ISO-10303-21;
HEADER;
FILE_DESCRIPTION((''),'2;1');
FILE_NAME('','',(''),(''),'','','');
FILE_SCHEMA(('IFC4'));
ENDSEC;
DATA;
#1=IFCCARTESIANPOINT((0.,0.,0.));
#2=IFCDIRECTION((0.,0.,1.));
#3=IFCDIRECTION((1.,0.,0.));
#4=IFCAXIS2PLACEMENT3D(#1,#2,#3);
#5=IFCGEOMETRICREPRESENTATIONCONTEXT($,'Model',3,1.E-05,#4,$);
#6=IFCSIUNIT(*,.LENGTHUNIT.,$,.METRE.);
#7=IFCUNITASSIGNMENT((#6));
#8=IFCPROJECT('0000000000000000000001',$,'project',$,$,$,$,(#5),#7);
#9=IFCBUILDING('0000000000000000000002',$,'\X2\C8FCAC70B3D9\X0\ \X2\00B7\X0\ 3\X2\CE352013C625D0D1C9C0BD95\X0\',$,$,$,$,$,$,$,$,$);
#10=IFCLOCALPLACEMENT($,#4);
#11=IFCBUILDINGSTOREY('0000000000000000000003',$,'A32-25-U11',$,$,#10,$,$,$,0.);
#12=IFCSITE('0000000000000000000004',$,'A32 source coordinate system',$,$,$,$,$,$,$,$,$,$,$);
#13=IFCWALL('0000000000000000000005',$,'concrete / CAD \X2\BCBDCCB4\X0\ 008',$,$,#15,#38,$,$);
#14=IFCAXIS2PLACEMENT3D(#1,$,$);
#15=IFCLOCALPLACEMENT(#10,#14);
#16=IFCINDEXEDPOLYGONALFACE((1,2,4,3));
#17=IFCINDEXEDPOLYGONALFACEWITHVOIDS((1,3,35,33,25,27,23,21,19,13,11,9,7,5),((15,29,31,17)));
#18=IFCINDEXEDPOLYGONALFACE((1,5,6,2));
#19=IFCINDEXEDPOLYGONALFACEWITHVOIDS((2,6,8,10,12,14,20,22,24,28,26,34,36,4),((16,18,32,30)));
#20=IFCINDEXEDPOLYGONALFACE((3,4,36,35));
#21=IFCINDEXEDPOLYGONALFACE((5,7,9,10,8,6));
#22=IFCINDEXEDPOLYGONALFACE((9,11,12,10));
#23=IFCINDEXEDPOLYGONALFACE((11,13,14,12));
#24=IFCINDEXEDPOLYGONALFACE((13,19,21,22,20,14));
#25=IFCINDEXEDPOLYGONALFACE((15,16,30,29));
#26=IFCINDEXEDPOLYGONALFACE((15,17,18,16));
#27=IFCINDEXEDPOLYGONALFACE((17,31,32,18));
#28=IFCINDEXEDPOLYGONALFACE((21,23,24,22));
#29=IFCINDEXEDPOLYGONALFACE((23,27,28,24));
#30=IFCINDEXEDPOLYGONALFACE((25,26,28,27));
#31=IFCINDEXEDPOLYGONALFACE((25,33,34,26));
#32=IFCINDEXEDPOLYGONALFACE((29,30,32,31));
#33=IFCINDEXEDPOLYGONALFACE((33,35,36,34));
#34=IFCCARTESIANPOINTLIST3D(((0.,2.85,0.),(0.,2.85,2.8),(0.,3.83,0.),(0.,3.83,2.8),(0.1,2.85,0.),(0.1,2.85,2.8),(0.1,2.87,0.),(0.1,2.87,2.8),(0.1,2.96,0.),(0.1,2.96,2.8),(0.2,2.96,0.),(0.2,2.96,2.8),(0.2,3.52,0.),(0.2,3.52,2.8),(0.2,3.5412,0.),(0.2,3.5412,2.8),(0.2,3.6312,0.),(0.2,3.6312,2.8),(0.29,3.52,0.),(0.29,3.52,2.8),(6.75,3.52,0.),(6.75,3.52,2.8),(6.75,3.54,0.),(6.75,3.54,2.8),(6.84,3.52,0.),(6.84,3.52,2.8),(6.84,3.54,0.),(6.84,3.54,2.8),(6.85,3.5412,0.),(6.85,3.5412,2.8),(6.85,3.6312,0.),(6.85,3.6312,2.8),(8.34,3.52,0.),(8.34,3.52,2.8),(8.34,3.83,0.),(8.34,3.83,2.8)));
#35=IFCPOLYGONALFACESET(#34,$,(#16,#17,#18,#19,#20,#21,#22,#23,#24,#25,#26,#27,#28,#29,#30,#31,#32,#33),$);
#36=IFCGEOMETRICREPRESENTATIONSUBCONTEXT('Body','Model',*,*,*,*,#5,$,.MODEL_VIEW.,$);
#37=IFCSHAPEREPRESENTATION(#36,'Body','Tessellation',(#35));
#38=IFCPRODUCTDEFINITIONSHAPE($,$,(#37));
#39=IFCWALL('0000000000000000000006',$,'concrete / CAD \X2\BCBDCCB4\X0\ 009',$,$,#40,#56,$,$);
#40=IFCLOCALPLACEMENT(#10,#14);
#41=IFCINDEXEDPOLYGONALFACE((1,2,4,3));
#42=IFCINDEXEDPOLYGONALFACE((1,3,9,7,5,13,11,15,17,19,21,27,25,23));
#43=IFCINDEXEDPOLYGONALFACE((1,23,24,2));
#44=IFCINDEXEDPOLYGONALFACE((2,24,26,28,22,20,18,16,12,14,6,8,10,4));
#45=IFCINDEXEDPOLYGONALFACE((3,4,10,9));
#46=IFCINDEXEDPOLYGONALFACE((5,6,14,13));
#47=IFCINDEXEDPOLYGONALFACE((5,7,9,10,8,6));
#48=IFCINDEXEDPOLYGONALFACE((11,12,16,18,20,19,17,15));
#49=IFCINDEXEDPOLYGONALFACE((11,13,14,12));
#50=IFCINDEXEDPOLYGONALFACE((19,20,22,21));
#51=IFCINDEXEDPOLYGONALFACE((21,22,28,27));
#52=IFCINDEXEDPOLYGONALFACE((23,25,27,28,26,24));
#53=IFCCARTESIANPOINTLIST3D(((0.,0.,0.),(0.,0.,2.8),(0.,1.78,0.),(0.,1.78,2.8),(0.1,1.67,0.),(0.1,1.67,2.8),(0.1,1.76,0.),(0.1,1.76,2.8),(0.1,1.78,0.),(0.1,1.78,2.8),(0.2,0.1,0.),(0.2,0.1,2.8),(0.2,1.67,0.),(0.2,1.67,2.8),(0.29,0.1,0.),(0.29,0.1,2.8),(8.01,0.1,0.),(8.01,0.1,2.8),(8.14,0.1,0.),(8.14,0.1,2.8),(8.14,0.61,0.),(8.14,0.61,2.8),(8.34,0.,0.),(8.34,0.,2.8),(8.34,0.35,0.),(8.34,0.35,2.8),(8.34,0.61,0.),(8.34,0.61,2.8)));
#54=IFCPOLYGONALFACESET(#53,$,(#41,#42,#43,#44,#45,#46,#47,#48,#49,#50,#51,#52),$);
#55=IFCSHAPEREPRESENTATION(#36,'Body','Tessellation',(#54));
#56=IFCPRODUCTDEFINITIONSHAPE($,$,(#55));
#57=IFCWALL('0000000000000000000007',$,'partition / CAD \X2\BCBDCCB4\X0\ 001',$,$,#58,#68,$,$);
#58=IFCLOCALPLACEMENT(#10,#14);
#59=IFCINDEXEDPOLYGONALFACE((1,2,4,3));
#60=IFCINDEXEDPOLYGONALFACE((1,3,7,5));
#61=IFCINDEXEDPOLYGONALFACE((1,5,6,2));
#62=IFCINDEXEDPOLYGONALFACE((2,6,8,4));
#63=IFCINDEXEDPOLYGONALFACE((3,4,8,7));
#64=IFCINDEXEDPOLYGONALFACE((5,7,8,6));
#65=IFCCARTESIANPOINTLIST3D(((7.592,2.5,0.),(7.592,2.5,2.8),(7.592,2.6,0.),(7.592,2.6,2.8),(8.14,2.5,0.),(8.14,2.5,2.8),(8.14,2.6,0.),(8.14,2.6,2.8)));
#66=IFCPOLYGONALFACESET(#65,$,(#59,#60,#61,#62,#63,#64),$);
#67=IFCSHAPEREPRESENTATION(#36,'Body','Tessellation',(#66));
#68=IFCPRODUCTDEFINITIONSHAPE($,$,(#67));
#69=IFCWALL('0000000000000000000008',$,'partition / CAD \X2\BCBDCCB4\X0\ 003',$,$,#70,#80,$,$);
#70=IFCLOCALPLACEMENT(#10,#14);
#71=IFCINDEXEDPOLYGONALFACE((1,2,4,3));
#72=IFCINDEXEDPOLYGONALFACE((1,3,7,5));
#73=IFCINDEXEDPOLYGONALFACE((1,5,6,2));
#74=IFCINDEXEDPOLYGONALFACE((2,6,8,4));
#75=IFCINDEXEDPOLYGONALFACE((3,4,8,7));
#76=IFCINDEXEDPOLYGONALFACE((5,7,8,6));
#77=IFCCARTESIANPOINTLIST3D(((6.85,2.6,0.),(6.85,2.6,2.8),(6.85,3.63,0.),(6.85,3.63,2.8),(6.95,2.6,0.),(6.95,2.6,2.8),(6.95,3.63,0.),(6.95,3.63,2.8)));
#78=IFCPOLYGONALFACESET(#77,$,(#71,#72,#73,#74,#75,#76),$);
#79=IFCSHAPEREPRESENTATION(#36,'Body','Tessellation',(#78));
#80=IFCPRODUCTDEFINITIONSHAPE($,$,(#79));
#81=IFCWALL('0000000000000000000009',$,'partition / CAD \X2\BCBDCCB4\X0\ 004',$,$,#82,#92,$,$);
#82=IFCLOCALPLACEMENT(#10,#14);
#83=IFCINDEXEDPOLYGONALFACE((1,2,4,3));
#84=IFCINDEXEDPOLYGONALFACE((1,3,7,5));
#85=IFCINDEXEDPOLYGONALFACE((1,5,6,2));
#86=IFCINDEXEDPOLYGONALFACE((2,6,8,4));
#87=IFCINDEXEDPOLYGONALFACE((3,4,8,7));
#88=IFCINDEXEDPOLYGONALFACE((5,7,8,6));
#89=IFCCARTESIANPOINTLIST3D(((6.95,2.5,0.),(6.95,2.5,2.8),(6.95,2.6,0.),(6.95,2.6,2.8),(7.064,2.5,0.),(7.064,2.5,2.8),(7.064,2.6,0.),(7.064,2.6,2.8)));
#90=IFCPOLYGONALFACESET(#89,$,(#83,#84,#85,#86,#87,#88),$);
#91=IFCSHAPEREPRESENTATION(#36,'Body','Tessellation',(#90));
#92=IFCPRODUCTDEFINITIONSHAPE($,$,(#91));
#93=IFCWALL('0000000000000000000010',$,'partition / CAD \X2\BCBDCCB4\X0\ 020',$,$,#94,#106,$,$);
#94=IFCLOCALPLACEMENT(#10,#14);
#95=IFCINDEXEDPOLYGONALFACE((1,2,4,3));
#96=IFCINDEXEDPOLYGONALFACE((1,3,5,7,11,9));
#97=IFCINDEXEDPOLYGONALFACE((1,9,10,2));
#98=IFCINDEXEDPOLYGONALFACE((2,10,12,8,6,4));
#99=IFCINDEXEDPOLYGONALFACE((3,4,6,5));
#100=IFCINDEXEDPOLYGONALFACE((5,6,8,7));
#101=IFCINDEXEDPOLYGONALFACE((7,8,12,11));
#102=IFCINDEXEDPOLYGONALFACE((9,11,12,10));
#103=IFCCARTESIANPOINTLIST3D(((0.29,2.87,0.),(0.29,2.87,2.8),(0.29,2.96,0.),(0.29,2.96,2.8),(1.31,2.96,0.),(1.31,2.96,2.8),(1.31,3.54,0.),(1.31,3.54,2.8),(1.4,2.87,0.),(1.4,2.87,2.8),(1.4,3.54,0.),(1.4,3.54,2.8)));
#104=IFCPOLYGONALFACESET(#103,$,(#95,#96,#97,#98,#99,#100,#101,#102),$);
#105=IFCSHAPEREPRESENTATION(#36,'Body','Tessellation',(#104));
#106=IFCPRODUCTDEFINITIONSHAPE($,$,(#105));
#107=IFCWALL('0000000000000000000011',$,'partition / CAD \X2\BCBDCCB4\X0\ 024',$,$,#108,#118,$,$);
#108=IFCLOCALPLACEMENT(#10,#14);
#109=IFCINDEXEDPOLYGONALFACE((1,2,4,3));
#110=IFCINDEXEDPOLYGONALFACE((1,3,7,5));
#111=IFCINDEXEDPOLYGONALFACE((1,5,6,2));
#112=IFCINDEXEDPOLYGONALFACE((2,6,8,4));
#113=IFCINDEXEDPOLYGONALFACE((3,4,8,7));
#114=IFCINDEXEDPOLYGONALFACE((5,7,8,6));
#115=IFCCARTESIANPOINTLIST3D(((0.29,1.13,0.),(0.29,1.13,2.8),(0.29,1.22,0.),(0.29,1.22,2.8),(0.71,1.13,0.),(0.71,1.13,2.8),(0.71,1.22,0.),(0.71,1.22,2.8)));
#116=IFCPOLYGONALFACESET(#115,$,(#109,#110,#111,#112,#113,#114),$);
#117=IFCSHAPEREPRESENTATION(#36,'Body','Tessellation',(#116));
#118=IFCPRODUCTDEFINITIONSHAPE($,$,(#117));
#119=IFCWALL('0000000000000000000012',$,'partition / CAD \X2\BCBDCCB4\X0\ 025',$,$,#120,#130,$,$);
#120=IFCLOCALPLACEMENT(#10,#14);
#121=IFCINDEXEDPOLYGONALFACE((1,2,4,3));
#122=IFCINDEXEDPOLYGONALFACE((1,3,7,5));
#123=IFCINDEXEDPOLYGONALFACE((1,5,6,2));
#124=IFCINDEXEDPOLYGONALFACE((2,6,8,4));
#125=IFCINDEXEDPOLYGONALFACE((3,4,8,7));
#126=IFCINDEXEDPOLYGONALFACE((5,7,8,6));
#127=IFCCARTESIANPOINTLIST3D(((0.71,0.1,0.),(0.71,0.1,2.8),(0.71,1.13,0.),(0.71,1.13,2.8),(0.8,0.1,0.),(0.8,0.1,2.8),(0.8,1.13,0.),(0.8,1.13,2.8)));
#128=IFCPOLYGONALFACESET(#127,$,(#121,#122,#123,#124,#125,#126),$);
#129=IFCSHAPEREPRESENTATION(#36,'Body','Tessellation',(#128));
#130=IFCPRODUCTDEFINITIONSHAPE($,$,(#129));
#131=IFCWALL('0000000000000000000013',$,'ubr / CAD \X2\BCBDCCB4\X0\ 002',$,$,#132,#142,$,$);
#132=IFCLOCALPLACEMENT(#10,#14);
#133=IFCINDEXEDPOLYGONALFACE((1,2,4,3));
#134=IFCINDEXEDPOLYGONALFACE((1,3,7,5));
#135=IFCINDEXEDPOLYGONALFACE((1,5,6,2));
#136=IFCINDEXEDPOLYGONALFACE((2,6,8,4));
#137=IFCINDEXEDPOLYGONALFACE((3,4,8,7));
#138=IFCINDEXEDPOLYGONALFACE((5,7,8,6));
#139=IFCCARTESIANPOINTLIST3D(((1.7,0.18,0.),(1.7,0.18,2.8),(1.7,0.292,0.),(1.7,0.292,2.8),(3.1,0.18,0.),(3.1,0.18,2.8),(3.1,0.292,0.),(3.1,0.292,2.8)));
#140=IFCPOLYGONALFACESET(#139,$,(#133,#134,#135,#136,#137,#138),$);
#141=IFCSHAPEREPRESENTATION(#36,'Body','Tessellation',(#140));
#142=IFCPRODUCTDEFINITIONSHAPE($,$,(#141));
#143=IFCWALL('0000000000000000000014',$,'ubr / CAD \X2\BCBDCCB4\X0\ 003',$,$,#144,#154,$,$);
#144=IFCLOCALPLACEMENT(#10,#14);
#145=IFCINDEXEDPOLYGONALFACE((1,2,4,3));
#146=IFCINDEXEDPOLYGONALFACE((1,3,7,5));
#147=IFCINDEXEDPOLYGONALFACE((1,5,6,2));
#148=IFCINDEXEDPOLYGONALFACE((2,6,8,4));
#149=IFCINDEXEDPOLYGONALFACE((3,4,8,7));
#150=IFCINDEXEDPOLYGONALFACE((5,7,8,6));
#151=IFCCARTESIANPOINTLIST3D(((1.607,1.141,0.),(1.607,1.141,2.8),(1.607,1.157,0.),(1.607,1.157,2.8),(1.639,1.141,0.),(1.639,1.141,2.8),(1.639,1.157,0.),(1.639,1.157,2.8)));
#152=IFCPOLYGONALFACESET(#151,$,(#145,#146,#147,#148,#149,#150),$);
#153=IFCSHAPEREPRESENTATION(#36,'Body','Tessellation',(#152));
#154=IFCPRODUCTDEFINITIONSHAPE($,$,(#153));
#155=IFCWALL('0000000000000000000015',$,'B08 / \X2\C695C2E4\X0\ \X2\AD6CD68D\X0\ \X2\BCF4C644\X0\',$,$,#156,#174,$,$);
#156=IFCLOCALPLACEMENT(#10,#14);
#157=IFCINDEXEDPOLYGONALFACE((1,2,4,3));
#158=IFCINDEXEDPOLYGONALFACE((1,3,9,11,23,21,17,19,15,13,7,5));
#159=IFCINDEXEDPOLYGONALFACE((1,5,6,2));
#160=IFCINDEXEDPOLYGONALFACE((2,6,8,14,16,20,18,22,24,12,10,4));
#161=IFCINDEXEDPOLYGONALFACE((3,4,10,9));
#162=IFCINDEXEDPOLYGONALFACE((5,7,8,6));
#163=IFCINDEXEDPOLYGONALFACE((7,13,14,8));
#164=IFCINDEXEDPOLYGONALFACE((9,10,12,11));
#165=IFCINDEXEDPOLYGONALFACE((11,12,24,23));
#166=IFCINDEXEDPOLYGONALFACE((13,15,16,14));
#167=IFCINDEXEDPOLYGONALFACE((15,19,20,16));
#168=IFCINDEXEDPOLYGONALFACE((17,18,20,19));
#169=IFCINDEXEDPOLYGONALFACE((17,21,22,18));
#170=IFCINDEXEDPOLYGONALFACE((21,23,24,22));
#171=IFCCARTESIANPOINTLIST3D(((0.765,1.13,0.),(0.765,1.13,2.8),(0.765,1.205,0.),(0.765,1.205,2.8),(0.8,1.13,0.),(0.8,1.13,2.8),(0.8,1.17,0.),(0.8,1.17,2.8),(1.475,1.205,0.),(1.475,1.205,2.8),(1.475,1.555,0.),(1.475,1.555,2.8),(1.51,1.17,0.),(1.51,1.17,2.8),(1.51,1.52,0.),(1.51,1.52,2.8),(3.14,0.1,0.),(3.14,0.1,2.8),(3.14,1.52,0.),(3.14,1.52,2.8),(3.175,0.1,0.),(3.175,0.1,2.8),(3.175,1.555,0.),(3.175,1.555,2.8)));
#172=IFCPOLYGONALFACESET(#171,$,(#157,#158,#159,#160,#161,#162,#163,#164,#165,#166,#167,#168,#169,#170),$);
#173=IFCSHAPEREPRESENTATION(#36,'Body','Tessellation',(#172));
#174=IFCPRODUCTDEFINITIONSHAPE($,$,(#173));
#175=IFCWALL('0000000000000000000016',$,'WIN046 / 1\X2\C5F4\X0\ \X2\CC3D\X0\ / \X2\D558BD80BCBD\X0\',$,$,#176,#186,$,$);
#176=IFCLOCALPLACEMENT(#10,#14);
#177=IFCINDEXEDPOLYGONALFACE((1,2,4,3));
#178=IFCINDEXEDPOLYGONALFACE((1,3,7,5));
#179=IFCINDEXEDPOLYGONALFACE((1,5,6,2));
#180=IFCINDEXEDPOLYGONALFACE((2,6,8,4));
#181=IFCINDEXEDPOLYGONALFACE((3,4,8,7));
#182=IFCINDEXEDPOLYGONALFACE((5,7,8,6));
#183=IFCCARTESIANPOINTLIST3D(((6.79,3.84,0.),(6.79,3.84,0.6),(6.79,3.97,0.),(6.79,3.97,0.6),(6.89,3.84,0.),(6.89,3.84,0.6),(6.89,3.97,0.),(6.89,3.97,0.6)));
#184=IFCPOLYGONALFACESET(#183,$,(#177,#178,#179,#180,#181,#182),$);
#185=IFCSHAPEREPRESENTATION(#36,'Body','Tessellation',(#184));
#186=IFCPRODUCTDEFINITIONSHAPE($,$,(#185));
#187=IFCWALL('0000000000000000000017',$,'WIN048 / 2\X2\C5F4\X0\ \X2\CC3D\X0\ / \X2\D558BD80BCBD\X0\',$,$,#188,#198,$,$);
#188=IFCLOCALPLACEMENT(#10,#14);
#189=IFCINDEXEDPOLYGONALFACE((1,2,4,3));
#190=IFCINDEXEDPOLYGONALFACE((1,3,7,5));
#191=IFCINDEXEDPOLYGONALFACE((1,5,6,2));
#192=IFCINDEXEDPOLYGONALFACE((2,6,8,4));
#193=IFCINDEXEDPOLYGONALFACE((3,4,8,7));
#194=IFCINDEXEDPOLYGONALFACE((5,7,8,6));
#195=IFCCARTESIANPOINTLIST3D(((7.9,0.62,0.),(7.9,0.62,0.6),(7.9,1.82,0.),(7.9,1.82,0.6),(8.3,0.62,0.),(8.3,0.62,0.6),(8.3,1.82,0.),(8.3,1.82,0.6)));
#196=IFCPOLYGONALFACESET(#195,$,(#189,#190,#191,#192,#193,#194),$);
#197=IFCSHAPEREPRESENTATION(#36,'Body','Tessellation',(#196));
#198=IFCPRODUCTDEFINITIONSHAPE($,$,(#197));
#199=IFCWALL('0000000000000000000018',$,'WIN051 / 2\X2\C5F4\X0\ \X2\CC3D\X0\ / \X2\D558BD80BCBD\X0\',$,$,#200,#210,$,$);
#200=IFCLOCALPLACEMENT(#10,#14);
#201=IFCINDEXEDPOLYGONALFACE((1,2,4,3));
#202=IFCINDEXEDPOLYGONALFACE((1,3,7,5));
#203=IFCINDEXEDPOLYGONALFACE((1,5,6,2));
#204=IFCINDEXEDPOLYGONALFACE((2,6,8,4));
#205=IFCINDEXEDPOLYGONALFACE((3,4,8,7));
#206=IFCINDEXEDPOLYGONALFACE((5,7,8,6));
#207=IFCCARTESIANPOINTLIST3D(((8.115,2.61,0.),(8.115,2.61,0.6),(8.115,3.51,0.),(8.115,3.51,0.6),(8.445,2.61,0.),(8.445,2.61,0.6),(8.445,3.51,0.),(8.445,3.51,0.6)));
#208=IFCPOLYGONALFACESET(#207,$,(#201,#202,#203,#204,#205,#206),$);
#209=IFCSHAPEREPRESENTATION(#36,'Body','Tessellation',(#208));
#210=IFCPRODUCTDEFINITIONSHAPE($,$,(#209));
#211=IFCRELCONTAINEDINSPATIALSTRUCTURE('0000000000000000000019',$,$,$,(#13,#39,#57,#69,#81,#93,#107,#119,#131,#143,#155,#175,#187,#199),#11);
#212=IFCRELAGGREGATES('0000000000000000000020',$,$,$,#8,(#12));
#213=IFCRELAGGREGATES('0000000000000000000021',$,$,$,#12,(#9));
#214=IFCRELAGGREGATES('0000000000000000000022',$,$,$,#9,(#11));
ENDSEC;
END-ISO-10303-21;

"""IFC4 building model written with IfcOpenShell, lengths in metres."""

from ifc_helpers import new_model, si_unit, origin, origin_with_axes, place, context, subcontext, project, spatial, polyline, outline, extrude, element, save


model = new_model("IFC4")

# Units and contexts
model_context = context("Model", 3, precision=1e-05, world=origin_with_axes())
body_context = subcontext(model_context, "Body", "Model", "MODEL_VIEW")
ifc_project = project(units=[si_unit("LENGTHUNIT", "METRE")], contexts=[model_context])

# Site, building, storey
site = spatial("IfcSite", under=ifc_project, Name="A32 source coordinate system")
building = spatial("IfcBuilding", under=site, Name="주거동 · 3층–옥탑지붕")
storey_placement = place(None, origin_with_axes())
storey = spatial("IfcBuildingStorey", under=building, at=storey_placement, Name="A32-25-U11", Elevation=0.0)

# Walls
wall_1_placement = place(storey_placement, origin_with_axes())
element("IfcWall", 1, at=wall_1_placement, inside=storey, Name="concrete / CAD 벽체 008", context=body_context, shape_type="SweptSolid", body=[
    extrude(outline(polyline([(0.0, 3.83), (8.34, 3.83), (8.34, 3.52), (6.84, 3.52), (6.84, 3.54), (6.75, 3.54), (6.75, 3.52), (0.29, 3.52), (0.2, 3.52), (0.2, 2.96), (0.1, 2.96), (0.1, 2.87), (0.1, 2.85), (0.0, 2.85), (0.0, 3.83)]), holes=[polyline([(6.85, 3.5412), (6.85, 3.6312), (0.2, 3.6312), (0.2, 3.5412), (6.85, 3.5412)])]), origin(), (0.0, 0.0, 1.0), 2.8),
])
wall_2_placement = place(storey_placement, origin_with_axes())
element("IfcWall", 2, at=wall_2_placement, inside=storey, Name="concrete / CAD 벽체 009", context=body_context, shape_type="SweptSolid", body=[
    extrude(outline(polyline([(8.34, 0.61), (8.34, 0.35), (8.34, 0.35), (8.34, 0.0), (0.0, 0.0), (0.0, 1.78), (0.1, 1.78), (0.1, 1.76), (0.1, 1.67), (0.2, 1.67), (0.2, 0.1), (0.29, 0.1), (8.01, 0.1), (8.14, 0.1), (8.14, 0.61), (8.34, 0.61)])), origin(), (0.0, 0.0, 1.0), 2.8),
])
wall_3_placement = place(storey_placement, origin_with_axes())
element("IfcWall", 3, at=wall_3_placement, inside=storey, Name="partition / CAD 벽체 001", context=body_context, shape_type="SweptSolid", body=[
    extrude(outline(polyline([(8.14, 2.6), (8.14, 2.5), (7.592, 2.5), (7.592, 2.6), (8.14, 2.6)])), origin(), (0.0, 0.0, 1.0), 2.8),
])
wall_4_placement = place(storey_placement, origin_with_axes())
element("IfcWall", 4, at=wall_4_placement, inside=storey, Name="partition / CAD 벽체 003", context=body_context, shape_type="SweptSolid", body=[
    extrude(outline(polyline([(6.85, 2.6), (6.85, 3.63), (6.95, 3.63), (6.95, 2.6), (6.85, 2.6)])), origin(), (0.0, 0.0, 1.0), 2.8),
])
wall_5_placement = place(storey_placement, origin_with_axes())
element("IfcWall", 5, at=wall_5_placement, inside=storey, Name="partition / CAD 벽체 004", context=body_context, shape_type="SweptSolid", body=[
    extrude(outline(polyline([(6.95, 2.5), (6.95, 2.6), (7.064, 2.6), (7.064, 2.5), (6.95, 2.5)])), origin(), (0.0, 0.0, 1.0), 2.8),
])
wall_6_placement = place(storey_placement, origin_with_axes())
element("IfcWall", 6, at=wall_6_placement, inside=storey, Name="partition / CAD 벽체 020", context=body_context, shape_type="SweptSolid", body=[
    extrude(outline(polyline([(0.29, 2.87), (0.29, 2.96), (1.31, 2.96), (1.31, 3.54), (1.4, 3.54), (1.4, 2.87), (0.29, 2.87)])), origin(), (0.0, 0.0, 1.0), 2.8),
])
wall_7_placement = place(storey_placement, origin_with_axes())
element("IfcWall", 7, at=wall_7_placement, inside=storey, Name="partition / CAD 벽체 024", context=body_context, shape_type="SweptSolid", body=[
    extrude(outline(polyline([(0.71, 1.13), (0.29, 1.13), (0.29, 1.22), (0.71, 1.22), (0.71, 1.13)])), origin(), (0.0, 0.0, 1.0), 2.8),
])
wall_8_placement = place(storey_placement, origin_with_axes())
element("IfcWall", 8, at=wall_8_placement, inside=storey, Name="partition / CAD 벽체 025", context=body_context, shape_type="SweptSolid", body=[
    extrude(outline(polyline([(0.71, 1.13), (0.8, 1.13), (0.8, 0.1), (0.71, 0.1), (0.71, 1.13)])), origin(), (0.0, 0.0, 1.0), 2.8),
])
wall_9_placement = place(storey_placement, origin_with_axes())
element("IfcWall", 9, at=wall_9_placement, inside=storey, Name="ubr / CAD 벽체 002", context=body_context, shape_type="SweptSolid", body=[
    extrude(outline(polyline([(3.1, 0.292), (3.1, 0.18), (1.7, 0.18), (1.7, 0.292), (3.1, 0.292)])), origin(), (0.0, 0.0, 1.0), 2.8),
])
wall_10_placement = place(storey_placement, origin_with_axes())
element("IfcWall", 10, at=wall_10_placement, inside=storey, Name="ubr / CAD 벽체 003", context=body_context, shape_type="SweptSolid", body=[
    extrude(outline(polyline([(1.639, 1.157), (1.639, 1.141), (1.607, 1.141), (1.607, 1.157), (1.639, 1.157)])), origin(), (0.0, 0.0, 1.0), 2.8),
])
wall_11_placement = place(storey_placement, origin_with_axes())
element("IfcWall", 11, at=wall_11_placement, inside=storey, Name="B08 / 욕실 구획 보완", context=body_context, shape_type="SweptSolid", body=[
    extrude(outline(polyline([(0.765, 1.205), (1.475, 1.205), (1.475, 1.555), (3.175, 1.555), (3.175, 0.1), (3.14, 0.1), (3.14, 1.52), (1.51, 1.52), (1.51, 1.17), (0.8, 1.17), (0.8, 1.13), (0.765, 1.13), (0.765, 1.205)])), origin(), (0.0, 0.0, 1.0), 2.8),
])
wall_12_placement = place(storey_placement, origin_with_axes())
element("IfcWall", 12, at=wall_12_placement, inside=storey, Name="WIN046 / 1열 창 / 하부벽", context=body_context, shape_type="SweptSolid", body=[
    extrude(outline(polyline([(6.89, 3.84), (6.79, 3.84), (6.79, 3.97), (6.89, 3.97), (6.89, 3.84)])), origin(), (0.0, 0.0, 1.0), 0.6),
])
wall_13_placement = place(storey_placement, origin_with_axes())
element("IfcWall", 13, at=wall_13_placement, inside=storey, Name="WIN048 / 2열 창 / 하부벽", context=body_context, shape_type="SweptSolid", body=[
    extrude(outline(polyline([(8.3, 0.62), (7.9, 0.62), (7.9, 1.82), (8.3, 1.82), (8.3, 0.62)])), origin(), (0.0, 0.0, 1.0), 0.6),
])
wall_14_placement = place(storey_placement, origin_with_axes())
element("IfcWall", 14, at=wall_14_placement, inside=storey, Name="WIN051 / 2열 창 / 하부벽", context=body_context, shape_type="SweptSolid", body=[
    extrude(outline(polyline([(8.445, 2.61), (8.115, 2.61), (8.115, 3.51), (8.445, 3.51), (8.445, 2.61)])), origin(), (0.0, 0.0, 1.0), 0.6),
])

save(model, "model.ifc")
